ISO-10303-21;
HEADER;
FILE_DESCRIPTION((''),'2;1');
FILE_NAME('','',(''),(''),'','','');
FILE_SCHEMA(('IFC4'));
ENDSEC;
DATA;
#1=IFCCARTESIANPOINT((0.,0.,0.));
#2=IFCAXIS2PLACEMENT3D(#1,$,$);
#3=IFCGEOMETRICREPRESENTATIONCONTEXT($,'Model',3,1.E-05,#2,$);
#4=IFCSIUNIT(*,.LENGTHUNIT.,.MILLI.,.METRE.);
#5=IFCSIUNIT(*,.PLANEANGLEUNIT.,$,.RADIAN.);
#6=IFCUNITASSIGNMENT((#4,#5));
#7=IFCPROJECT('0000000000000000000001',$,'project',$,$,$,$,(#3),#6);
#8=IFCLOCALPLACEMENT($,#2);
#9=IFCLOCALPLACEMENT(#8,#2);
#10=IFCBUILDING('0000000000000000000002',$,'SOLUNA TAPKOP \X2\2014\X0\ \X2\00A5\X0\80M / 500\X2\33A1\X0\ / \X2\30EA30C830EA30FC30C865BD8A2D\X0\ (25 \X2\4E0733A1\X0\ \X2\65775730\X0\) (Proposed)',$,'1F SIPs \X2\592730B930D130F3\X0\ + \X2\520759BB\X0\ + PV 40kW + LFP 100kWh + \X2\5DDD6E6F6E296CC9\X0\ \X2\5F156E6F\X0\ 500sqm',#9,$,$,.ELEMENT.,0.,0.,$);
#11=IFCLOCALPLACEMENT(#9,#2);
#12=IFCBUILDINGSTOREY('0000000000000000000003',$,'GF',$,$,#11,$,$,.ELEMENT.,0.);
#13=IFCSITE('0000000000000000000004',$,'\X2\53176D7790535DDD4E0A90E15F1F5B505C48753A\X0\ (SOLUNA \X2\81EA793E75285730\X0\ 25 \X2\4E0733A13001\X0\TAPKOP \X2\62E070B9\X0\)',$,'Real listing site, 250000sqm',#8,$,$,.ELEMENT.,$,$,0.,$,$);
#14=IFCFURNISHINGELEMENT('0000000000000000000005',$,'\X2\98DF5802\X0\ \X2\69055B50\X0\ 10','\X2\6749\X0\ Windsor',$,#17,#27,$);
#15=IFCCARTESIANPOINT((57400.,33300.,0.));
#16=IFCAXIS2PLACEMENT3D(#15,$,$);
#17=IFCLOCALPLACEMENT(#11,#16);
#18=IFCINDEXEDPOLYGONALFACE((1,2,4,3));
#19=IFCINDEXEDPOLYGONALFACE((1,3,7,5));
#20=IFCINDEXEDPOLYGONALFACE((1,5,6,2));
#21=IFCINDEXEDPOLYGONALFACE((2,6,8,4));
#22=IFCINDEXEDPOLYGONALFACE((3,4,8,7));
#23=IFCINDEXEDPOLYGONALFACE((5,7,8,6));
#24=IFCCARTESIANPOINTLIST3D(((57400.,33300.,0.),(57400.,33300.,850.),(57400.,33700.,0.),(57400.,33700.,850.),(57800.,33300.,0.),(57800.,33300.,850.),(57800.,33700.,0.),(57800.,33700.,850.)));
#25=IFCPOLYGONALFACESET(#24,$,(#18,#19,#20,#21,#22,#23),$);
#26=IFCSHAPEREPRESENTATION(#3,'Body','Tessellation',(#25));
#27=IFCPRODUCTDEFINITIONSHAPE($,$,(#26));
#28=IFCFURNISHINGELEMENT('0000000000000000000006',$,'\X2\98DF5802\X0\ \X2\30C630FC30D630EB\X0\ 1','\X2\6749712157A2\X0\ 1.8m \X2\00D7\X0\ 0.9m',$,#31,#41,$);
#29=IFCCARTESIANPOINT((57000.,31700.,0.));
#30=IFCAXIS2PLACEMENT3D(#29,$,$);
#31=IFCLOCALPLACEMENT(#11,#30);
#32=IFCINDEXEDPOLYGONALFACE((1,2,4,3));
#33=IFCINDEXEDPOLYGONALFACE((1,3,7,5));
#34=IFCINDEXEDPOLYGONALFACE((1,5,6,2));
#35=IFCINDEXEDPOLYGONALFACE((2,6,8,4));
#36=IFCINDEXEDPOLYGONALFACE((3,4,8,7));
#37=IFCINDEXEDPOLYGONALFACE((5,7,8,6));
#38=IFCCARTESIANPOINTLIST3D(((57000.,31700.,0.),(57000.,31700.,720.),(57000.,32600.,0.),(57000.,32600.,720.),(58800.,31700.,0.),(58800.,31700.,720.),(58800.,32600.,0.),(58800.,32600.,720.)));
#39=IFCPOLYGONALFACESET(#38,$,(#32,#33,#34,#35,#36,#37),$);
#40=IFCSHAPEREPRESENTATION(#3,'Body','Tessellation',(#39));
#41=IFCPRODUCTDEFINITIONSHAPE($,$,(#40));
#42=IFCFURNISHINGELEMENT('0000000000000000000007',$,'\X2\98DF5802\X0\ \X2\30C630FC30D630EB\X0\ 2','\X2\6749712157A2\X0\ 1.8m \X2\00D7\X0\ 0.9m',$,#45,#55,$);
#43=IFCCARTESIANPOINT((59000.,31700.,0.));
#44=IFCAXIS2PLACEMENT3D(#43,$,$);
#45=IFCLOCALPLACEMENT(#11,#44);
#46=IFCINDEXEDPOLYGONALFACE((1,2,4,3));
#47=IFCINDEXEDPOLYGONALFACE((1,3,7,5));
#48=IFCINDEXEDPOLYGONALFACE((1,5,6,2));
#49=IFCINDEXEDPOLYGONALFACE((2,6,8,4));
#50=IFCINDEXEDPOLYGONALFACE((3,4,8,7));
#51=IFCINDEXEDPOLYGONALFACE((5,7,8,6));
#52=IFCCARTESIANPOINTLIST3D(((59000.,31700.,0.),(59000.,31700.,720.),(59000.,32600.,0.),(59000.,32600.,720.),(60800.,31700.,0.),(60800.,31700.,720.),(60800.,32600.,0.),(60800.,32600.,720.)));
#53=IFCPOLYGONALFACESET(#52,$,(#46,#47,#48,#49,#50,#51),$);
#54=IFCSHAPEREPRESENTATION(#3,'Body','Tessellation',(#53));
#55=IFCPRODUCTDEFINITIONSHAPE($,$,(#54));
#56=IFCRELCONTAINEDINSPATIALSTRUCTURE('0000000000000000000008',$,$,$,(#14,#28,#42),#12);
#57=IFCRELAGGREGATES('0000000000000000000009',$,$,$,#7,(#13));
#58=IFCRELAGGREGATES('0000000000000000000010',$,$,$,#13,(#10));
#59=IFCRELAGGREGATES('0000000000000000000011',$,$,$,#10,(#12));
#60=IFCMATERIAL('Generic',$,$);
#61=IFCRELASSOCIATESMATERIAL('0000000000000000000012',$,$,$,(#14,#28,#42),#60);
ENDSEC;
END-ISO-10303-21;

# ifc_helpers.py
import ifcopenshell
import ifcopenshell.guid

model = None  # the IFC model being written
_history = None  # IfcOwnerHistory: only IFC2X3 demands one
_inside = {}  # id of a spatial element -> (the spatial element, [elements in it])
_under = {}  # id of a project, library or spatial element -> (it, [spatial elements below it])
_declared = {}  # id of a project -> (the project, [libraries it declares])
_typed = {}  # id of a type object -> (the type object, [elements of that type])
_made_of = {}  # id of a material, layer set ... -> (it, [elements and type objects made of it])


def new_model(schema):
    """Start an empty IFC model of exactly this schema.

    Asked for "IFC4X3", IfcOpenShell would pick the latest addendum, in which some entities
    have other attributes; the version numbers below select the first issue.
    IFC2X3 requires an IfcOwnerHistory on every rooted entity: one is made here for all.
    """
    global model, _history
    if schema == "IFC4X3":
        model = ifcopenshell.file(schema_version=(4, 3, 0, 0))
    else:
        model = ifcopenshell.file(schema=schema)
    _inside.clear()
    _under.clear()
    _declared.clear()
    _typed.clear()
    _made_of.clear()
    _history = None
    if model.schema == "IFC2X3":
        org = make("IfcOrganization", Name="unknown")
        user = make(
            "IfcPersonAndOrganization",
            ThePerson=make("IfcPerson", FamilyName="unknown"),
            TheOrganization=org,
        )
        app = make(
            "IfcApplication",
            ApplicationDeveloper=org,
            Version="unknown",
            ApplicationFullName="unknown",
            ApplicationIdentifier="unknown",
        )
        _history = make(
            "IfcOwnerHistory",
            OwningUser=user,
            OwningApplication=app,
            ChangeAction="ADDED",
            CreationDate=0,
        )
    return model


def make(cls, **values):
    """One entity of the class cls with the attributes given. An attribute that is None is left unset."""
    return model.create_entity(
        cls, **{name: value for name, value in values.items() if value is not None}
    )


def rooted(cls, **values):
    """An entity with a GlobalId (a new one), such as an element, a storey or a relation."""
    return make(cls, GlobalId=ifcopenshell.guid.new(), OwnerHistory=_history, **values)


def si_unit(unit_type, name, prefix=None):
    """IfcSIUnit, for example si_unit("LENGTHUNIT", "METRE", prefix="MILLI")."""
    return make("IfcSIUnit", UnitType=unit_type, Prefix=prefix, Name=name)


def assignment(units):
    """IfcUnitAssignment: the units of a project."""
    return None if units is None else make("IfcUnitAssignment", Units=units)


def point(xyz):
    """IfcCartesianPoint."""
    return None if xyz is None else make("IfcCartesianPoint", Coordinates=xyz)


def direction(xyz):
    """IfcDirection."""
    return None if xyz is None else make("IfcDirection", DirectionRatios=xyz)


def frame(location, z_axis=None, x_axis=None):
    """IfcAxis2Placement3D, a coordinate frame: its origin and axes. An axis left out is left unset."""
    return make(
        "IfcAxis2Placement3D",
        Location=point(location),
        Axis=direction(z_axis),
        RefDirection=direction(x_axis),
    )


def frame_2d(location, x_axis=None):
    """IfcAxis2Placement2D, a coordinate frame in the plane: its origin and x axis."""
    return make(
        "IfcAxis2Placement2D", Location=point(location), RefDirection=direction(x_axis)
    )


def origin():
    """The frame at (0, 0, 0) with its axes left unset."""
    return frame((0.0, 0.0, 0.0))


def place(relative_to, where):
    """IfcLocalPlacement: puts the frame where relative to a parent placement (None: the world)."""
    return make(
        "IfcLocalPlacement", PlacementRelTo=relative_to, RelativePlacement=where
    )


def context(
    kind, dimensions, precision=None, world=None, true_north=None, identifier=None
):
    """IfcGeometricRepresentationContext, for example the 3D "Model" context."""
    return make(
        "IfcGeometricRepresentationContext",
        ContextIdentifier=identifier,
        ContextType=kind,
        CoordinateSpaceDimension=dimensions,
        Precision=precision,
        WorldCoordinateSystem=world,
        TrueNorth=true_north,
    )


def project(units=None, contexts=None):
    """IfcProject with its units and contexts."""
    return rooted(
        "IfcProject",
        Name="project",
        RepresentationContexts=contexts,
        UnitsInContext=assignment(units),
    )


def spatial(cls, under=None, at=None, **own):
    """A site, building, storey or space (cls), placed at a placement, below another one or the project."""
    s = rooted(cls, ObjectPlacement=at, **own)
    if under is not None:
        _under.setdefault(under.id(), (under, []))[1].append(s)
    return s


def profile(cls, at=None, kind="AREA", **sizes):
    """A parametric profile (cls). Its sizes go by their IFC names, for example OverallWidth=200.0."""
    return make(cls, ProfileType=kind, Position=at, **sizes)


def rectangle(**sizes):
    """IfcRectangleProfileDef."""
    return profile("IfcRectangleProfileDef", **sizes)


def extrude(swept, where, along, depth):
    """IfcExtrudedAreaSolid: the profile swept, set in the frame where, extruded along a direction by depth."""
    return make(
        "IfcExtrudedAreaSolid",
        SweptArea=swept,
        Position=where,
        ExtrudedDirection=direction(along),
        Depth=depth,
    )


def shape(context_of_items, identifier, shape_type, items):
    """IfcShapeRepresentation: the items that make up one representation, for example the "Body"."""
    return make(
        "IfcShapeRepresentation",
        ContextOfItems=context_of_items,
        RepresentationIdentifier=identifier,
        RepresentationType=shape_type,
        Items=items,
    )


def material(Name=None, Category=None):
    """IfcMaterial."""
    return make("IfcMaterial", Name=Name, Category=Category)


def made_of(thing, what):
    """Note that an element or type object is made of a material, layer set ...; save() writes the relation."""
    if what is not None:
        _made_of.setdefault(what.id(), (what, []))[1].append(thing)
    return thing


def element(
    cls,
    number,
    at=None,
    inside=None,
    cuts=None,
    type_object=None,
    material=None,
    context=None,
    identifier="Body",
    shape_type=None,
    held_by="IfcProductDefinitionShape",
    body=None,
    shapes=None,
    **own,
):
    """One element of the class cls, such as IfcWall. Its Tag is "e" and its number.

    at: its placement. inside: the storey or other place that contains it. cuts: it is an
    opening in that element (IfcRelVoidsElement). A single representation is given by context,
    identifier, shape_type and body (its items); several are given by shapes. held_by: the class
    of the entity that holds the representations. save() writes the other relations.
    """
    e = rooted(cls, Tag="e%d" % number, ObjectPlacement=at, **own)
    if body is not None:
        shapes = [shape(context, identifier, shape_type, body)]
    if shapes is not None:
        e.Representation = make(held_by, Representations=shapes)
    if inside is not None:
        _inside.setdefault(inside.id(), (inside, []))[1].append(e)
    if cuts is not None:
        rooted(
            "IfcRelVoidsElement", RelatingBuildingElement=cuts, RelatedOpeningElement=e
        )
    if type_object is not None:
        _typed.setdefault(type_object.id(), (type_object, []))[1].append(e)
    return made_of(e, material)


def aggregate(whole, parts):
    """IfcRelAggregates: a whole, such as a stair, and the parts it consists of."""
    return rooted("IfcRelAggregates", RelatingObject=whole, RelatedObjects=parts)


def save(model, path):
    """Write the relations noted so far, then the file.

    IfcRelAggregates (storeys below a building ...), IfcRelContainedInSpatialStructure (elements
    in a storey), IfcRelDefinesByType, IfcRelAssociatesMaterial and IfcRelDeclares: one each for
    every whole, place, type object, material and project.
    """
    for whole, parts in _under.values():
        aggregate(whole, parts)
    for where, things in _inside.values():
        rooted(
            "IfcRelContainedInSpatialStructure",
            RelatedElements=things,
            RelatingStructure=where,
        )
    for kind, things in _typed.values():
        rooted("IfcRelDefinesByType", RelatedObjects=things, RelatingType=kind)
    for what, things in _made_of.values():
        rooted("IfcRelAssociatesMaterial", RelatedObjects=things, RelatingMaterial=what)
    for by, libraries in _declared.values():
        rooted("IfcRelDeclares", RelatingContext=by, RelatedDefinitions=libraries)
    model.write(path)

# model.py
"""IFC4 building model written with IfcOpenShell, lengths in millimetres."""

from ifc_helpers import new_model, si_unit, frame, frame_2d, origin, place, context, project, spatial, rectangle, extrude, material, element, save


model = new_model("IFC4")

# Units and contexts
model_context = context("Model", 3, precision=1e-05, world=origin())
ifc_project = project(units=[si_unit("LENGTHUNIT", "METRE", prefix="MILLI"), si_unit("PLANEANGLEUNIT", "RADIAN")], contexts=[model_context])

# Site, building, storey
site_placement = place(None, origin())
site = spatial("IfcSite", under=ifc_project, at=site_placement, Name="北海道川上郡弟子屈町 (SOLUNA 自社用地 25 万㎡、TAPKOP 拠点)", ObjectType="Real listing site, 250000sqm", CompositionType="ELEMENT", RefElevation=0.0)
building_placement = place(site_placement, origin())
building = spatial("IfcBuilding", under=site, at=building_placement, Name="SOLUNA TAPKOP — ¥80M / 500㎡ / リトリート施設 (25 万㎡ 敷地) (Proposed)", ObjectType="1F SIPs 大スパン + 切妻 + PV 40kW + LFP 100kWh + 川湯温泉 引湯 500sqm", CompositionType="ELEMENT", ElevationOfRefHeight=0.0, ElevationOfTerrain=0.0)
storey_placement = place(building_placement, origin())
storey = spatial("IfcBuildingStorey", under=building, at=storey_placement, Name="GF", CompositionType="ELEMENT", Elevation=0.0)

# Shared definitions
ifc_material = material(Name="Generic")

# Furnishing elements
furnishing_1_placement = place(storey_placement, frame((57400.0, 33300.0, 0.0)))
element("IfcFurnishingElement", 1, at=furnishing_1_placement, inside=storey, material=ifc_material, Name="食堂 椅子 10", Description="杉 Windsor", context=model_context, shape_type="SweptSolid", body=[
    extrude(rectangle(XDim=400.0, YDim=400.0, at=frame_2d((200.0, 200.0))), frame((57400.0, 33300.0, 0.0)), (0.0, 0.0, 1.0), 850.0),
])
furnishing_2_placement = place(storey_placement, frame((57000.0, 31700.0, 0.0)))
element("IfcFurnishingElement", 2, at=furnishing_2_placement, inside=storey, material=ifc_material, Name="食堂 テーブル 1", Description="杉無垢 1.8m × 0.9m", context=model_context, shape_type="SweptSolid", body=[
    extrude(rectangle(XDim=1800.0, YDim=900.0, at=frame_2d((900.0, 450.0))), frame((57000.0, 31700.0, 0.0)), (0.0, 0.0, 1.0), 720.0),
])
furnishing_3_placement = place(storey_placement, frame((59000.0, 31700.0, 0.0)))
element("IfcFurnishingElement", 3, at=furnishing_3_placement, inside=storey, material=ifc_material, Name="食堂 テーブル 2", Description="杉無垢 1.8m × 0.9m", context=model_context, shape_type="SweptSolid", body=[
    extrude(rectangle(XDim=1800.0, YDim=900.0, at=frame_2d((900.0, 450.0))), frame((59000.0, 31700.0, 0.0)), (0.0, 0.0, 1.0), 720.0),
])

save(model, "model.ifc")
